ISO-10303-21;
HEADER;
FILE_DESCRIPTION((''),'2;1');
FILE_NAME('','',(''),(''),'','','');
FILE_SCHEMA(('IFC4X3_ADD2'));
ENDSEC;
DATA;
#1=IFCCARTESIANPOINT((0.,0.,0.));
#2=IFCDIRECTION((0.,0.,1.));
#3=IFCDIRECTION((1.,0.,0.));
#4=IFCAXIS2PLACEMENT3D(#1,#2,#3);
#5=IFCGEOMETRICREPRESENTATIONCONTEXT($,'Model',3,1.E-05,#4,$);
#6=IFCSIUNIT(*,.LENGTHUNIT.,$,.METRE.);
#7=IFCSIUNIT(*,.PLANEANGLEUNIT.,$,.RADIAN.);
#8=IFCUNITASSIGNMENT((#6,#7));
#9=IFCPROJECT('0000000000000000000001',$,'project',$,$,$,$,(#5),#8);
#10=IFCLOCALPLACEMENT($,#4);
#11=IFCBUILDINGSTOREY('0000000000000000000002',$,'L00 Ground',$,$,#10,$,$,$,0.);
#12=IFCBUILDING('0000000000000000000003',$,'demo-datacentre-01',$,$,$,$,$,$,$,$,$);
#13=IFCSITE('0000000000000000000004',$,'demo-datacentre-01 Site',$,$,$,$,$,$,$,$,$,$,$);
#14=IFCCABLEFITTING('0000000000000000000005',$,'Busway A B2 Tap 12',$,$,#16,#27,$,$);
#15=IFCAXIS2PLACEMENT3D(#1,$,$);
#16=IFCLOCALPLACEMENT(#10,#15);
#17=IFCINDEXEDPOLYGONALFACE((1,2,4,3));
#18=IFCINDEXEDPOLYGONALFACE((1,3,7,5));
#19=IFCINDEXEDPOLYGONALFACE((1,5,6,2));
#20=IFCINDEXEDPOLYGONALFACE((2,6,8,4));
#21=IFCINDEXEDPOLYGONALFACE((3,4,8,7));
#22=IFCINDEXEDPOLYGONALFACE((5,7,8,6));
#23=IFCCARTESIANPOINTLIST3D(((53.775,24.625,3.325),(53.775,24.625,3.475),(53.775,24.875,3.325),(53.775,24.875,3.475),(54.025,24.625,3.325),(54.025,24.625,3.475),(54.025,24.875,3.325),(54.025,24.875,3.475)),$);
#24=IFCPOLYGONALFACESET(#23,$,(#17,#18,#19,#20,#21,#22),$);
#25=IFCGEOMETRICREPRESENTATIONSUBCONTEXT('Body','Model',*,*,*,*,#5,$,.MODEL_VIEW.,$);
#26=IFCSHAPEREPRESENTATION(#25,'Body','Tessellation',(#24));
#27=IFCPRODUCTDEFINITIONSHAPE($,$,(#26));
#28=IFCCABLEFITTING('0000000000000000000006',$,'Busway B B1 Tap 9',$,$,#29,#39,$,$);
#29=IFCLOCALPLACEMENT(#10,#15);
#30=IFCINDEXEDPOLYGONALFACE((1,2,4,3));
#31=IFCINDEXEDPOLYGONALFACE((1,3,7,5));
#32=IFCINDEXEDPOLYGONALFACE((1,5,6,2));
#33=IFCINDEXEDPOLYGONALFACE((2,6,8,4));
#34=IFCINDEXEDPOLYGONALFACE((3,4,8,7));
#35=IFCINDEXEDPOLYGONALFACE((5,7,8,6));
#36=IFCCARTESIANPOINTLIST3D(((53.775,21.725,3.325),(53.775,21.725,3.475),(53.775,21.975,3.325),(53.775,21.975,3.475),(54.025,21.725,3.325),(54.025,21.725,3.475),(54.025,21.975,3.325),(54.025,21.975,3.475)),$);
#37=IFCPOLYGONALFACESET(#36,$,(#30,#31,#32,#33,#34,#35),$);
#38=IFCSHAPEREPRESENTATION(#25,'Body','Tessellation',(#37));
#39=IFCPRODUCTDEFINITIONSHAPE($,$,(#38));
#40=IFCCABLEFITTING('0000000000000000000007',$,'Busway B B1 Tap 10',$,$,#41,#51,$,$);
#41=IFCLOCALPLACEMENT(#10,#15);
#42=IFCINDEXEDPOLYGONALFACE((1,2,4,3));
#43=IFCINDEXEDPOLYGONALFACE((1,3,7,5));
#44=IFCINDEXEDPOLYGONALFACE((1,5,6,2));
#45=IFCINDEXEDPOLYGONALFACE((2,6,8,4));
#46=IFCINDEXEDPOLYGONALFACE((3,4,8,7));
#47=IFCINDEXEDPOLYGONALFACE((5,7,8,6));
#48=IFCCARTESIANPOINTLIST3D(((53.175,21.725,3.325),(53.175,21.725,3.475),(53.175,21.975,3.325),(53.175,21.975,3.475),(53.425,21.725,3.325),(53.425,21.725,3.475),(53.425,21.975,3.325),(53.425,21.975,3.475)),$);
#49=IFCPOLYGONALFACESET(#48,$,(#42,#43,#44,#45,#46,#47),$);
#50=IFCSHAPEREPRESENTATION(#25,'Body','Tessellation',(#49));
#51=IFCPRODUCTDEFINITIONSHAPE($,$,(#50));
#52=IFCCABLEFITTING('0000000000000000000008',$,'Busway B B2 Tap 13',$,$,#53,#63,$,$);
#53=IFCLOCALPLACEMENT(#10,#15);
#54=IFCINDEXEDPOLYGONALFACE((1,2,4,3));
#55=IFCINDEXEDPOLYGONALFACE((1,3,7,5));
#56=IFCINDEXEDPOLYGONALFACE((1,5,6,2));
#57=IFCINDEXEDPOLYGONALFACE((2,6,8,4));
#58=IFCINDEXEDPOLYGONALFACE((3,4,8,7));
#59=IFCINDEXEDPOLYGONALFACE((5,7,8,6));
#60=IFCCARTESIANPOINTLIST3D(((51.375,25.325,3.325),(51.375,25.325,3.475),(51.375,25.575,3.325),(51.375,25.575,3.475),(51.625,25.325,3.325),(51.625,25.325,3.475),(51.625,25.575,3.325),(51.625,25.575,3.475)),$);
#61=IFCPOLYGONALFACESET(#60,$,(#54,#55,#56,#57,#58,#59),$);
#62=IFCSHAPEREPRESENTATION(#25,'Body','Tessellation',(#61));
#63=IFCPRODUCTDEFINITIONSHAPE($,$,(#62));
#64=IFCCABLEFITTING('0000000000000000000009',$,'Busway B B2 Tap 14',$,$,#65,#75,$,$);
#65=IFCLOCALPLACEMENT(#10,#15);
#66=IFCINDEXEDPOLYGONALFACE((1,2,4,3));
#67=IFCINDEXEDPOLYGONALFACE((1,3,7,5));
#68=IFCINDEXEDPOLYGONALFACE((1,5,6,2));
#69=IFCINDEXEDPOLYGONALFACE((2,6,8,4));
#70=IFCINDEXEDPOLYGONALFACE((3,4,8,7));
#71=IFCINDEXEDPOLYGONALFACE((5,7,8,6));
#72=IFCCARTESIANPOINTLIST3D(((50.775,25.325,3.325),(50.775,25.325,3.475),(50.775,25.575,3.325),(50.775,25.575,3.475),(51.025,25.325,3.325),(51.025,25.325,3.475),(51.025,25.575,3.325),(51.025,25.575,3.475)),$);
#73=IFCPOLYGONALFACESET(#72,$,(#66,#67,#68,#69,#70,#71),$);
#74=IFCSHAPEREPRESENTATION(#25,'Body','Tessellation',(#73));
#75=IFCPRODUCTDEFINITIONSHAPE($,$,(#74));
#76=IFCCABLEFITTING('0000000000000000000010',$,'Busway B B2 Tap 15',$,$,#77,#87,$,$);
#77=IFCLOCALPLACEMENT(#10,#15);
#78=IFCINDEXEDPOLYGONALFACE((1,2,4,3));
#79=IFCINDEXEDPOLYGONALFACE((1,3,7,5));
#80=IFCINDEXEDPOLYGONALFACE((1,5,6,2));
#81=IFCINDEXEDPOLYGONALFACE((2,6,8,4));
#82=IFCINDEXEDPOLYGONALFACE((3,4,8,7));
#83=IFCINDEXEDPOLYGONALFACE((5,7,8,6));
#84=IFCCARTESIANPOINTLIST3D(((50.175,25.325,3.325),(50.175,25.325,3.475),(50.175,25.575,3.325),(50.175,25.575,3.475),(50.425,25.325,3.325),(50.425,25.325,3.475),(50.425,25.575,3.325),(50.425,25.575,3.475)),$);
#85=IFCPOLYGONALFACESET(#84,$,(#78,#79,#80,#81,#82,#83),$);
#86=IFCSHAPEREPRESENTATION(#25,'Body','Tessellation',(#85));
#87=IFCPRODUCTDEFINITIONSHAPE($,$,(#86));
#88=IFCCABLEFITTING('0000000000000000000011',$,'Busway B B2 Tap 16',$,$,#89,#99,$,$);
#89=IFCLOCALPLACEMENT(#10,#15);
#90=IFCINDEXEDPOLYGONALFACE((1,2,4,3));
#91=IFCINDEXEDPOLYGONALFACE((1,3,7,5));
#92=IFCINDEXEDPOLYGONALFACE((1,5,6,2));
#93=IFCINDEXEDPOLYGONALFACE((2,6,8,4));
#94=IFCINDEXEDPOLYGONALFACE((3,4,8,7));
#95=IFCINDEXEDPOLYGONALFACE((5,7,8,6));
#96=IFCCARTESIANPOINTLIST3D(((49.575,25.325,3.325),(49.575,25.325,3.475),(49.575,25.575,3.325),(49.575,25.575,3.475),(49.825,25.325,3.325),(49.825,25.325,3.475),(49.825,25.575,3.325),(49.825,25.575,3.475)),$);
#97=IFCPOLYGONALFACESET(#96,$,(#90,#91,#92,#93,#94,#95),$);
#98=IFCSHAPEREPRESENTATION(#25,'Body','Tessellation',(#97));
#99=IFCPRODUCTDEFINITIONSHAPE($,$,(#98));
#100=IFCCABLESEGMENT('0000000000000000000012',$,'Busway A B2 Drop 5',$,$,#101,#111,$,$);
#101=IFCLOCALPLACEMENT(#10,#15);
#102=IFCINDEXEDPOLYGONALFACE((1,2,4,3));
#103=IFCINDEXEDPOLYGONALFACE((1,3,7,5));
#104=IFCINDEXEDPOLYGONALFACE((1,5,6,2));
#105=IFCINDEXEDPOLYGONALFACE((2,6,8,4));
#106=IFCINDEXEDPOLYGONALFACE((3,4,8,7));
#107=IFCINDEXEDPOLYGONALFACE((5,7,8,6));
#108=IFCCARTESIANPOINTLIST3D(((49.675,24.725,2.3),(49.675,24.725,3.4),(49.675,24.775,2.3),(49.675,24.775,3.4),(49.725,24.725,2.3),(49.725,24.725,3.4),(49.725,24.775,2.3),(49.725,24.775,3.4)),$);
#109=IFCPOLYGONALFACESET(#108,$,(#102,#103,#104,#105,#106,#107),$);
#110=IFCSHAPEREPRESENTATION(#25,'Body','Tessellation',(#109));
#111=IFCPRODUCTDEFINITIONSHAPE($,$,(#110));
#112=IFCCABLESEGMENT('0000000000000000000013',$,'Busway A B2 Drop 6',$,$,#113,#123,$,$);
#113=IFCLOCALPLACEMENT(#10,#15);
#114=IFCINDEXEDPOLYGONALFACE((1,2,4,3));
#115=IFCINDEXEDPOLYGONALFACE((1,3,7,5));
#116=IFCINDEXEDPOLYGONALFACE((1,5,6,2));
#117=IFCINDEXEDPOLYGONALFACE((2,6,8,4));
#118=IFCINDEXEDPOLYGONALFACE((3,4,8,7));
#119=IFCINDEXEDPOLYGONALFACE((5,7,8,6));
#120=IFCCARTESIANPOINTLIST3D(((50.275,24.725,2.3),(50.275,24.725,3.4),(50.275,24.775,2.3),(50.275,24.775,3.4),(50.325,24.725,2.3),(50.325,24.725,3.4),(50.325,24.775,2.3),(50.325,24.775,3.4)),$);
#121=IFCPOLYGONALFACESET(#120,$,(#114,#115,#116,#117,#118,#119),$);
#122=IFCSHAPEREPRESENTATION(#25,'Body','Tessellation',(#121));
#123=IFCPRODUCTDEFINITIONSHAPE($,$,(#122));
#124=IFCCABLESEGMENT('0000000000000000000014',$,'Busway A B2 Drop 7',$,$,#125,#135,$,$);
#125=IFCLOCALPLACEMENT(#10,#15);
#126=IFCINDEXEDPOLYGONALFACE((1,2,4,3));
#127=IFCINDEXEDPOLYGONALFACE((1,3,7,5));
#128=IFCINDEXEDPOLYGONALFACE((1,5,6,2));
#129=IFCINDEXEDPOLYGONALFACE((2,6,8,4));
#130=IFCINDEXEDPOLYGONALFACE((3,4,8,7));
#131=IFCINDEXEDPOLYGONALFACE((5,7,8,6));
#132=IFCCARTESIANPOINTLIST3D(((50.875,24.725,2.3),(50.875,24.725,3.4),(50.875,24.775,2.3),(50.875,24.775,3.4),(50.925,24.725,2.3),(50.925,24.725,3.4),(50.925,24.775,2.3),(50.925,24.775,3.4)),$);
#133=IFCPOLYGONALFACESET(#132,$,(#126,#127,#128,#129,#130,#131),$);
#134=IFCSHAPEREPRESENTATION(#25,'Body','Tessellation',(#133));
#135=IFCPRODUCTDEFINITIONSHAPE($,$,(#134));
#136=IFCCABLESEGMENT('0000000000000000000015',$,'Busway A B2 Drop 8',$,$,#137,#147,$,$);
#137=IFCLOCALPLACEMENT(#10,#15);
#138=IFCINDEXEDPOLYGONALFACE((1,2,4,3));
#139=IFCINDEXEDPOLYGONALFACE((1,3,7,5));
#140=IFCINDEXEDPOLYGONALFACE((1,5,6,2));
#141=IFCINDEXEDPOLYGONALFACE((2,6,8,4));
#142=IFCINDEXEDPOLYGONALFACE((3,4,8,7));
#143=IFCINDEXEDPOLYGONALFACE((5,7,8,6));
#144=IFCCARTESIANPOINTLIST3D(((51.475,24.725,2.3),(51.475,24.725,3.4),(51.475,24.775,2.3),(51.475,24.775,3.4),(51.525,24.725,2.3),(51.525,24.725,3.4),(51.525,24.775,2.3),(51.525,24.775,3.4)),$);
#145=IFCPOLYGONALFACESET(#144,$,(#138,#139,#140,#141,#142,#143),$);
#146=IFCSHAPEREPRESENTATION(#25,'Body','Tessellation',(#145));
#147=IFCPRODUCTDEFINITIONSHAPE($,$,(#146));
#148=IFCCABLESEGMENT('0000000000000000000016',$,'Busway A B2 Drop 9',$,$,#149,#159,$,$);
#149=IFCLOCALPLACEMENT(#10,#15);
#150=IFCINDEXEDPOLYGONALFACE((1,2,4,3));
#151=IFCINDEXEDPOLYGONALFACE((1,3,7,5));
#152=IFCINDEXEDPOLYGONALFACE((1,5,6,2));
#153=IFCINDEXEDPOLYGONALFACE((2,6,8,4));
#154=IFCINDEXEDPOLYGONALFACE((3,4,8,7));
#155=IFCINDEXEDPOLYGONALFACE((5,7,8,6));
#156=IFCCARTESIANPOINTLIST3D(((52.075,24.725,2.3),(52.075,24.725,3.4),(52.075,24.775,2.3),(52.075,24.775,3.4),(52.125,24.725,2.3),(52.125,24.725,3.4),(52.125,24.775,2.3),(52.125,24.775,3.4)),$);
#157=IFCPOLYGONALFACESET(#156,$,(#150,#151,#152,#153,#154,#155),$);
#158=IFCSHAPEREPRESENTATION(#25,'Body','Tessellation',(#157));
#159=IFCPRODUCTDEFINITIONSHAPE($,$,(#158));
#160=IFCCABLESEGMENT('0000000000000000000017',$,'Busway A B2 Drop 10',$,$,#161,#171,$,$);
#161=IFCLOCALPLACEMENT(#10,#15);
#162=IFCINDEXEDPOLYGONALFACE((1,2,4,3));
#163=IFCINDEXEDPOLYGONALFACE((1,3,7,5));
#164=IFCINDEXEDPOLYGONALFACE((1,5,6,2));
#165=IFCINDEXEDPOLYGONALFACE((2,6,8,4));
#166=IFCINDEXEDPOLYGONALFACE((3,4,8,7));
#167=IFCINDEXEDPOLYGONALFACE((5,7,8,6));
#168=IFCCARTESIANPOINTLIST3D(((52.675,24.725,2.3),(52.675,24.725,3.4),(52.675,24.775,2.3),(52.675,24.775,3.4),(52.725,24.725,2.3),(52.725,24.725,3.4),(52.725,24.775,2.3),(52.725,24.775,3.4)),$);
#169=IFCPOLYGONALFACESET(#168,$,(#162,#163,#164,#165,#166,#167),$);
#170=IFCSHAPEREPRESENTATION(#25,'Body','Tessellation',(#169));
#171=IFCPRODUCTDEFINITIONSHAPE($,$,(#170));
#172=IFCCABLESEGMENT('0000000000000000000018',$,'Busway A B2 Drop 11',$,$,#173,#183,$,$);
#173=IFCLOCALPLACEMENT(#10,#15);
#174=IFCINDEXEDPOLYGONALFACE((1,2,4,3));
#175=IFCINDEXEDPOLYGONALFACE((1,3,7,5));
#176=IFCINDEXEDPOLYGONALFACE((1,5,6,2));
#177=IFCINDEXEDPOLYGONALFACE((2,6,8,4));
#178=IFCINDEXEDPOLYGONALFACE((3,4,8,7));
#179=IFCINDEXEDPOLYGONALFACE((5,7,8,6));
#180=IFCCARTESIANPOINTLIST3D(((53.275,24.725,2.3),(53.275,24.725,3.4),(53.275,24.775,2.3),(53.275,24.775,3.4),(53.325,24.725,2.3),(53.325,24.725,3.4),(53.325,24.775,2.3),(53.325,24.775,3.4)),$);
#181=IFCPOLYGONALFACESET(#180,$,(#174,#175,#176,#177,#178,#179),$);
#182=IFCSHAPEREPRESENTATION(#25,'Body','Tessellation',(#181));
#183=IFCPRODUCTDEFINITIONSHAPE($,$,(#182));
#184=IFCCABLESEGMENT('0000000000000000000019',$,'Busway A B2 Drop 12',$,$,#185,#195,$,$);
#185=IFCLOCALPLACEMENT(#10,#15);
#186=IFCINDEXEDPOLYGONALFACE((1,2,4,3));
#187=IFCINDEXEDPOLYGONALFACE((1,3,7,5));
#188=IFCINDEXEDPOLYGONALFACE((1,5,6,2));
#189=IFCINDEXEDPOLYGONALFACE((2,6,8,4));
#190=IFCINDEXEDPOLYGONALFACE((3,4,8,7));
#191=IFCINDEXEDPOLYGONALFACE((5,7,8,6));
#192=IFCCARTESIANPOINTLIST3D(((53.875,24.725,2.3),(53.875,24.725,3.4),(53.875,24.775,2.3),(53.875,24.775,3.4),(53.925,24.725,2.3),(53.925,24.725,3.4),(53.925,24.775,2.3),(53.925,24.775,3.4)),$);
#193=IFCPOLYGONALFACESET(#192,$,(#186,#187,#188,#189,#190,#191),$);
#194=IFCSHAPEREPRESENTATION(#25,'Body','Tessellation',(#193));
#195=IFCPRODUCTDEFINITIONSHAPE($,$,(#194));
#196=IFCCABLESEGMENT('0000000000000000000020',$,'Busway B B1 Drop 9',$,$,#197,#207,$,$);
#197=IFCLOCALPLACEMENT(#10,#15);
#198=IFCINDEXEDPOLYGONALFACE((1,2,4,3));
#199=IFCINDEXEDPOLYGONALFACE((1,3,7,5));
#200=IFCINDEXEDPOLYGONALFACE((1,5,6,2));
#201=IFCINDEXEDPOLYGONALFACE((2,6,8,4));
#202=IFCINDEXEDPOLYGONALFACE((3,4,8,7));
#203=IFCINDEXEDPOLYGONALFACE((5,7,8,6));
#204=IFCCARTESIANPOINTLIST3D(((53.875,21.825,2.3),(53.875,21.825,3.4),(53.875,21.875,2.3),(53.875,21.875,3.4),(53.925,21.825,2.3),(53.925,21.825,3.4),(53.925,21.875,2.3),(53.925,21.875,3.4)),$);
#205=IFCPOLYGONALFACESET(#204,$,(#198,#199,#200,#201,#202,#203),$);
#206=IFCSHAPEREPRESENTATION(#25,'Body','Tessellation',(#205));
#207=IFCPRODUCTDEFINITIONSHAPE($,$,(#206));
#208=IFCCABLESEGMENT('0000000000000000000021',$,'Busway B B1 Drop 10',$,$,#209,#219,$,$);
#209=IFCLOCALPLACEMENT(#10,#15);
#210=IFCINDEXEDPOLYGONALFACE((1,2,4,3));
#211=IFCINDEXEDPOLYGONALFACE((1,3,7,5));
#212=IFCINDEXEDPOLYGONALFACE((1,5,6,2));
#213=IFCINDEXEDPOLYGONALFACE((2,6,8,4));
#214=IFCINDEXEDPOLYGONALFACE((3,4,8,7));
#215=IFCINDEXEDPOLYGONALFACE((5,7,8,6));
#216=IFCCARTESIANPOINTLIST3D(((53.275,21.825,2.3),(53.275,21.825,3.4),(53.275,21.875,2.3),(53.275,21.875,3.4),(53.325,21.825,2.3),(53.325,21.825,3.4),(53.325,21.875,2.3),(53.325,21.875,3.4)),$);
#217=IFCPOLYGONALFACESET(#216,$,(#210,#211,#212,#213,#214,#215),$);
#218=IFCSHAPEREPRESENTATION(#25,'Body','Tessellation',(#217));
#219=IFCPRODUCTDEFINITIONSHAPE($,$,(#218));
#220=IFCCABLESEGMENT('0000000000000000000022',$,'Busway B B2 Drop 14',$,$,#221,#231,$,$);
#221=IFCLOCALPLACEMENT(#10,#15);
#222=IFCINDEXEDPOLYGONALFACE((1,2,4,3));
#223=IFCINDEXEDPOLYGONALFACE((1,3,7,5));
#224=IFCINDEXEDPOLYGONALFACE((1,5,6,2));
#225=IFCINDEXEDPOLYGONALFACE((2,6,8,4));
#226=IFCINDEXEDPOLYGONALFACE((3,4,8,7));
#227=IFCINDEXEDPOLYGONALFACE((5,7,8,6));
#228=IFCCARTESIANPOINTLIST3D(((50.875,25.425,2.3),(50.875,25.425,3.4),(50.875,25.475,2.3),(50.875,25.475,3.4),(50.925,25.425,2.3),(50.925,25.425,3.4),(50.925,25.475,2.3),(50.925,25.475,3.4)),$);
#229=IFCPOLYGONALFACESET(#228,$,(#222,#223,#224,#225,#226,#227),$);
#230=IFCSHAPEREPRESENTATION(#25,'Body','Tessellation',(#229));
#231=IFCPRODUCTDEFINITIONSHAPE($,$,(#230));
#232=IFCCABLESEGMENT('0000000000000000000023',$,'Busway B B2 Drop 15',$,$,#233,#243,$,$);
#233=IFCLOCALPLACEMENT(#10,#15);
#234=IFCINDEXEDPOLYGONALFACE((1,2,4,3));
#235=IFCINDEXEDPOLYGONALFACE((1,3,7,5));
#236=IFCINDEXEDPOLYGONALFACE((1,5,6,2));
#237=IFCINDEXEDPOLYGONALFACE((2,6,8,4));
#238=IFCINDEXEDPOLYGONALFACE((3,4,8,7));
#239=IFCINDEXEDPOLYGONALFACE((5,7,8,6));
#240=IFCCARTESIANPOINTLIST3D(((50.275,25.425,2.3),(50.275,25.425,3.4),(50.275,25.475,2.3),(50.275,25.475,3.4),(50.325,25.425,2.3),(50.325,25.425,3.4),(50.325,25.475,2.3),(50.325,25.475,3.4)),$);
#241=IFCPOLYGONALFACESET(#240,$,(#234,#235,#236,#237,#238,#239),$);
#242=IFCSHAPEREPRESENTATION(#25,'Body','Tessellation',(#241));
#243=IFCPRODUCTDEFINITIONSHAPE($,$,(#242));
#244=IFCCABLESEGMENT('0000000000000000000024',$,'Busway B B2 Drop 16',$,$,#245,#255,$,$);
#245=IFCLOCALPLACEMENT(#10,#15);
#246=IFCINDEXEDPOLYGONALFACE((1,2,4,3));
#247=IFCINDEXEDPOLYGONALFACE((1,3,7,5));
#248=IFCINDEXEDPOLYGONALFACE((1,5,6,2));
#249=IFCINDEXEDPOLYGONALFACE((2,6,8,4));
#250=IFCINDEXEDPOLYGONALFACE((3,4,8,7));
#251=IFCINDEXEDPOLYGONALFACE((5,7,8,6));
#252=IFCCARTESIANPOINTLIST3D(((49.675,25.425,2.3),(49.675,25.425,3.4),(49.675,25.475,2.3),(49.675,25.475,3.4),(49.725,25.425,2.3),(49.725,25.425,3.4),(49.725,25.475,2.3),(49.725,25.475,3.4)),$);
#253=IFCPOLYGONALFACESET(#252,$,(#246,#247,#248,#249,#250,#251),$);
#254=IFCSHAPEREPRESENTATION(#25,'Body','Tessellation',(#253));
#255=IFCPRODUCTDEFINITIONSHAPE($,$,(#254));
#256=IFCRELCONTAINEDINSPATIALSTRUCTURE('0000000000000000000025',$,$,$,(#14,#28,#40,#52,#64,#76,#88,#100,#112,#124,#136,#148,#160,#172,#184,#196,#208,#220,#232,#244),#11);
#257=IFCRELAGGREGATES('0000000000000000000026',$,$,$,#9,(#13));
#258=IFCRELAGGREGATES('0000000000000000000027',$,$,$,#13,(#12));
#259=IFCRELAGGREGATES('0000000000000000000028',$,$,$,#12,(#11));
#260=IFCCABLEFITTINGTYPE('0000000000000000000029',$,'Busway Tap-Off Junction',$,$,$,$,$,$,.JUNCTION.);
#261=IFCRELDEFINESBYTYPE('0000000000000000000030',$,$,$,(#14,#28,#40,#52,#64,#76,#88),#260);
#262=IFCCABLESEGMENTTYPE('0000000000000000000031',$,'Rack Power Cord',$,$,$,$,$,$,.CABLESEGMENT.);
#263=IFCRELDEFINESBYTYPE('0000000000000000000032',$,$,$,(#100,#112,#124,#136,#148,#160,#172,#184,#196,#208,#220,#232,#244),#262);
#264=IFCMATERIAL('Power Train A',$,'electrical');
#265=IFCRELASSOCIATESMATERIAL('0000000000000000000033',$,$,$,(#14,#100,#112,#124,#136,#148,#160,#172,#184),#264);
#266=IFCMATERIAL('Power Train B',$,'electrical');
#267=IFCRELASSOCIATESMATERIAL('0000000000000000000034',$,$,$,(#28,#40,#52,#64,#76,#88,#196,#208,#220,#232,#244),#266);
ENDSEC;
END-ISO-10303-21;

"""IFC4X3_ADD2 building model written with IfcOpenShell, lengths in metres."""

from ifc_helpers import new_model, si_unit, frame, origin_with_axes, place, context, subcontext, project, spatial, rectangle, extrude, material, type_object, element, save


model = new_model("IFC4X3_ADD2")

# Units and contexts
model_context = context("Model", 3, precision=1e-05, world=origin_with_axes())
body_context = subcontext(model_context, "Body", "Model", "MODEL_VIEW")
ifc_project = project(units=[si_unit("LENGTHUNIT", "METRE"), si_unit("PLANEANGLEUNIT", "RADIAN")], contexts=[model_context])

# Site, building, storey
site = spatial("IfcSite", under=ifc_project, Name="demo-datacentre-01 Site")
building = spatial("IfcBuilding", under=site, Name="demo-datacentre-01")
storey_placement = place(None, origin_with_axes())
storey = spatial("IfcBuildingStorey", under=building, at=storey_placement, Name="L00 Ground", Elevation=0.0)

# Shared definitions
ifc_material_1 = material(Name="Power Train A", Category="electrical")
ifc_material_2 = material(Name="Power Train B", Category="electrical")

# Cable fittings
cable_fitting_type = type_object("IfcCableFittingType", Name="Busway Tap-Off Junction", PredefinedType="JUNCTION")
for number, where, z_axis, x_axis, name in (
    (1, (53.9, 24.75, 3.325), (0.0, 0.0, 1.0), (1.0, 0.0, 0.0), "Busway A B2 Tap 12"),
):
    element("IfcCableFitting", number, at=place(storey_placement, frame(where, z_axis=z_axis, x_axis=x_axis)), inside=storey, type_object=cable_fitting_type, material=ifc_material_1, Name=name, context=body_context, shape_type="SweptSolid", body=[
        extrude(rectangle(XDim=0.25, YDim=0.25), origin_with_axes(), (0.0, 0.0, 1.0), 0.15),
    ])
for number, where, z_axis, x_axis, name in (
    (2, (53.9, 21.85, 3.325), (0.0, 0.0, 1.0), (1.0, 0.0, 0.0), "Busway B B1 Tap 9"),
    (3, (53.3, 21.85, 3.325), (0.0, 0.0, 1.0), (1.0, 0.0, 0.0), "Busway B B1 Tap 10"),
    (4, (51.5, 25.45, 3.325), (0.0, 0.0, 1.0), (1.0, 0.0, 0.0), "Busway B B2 Tap 13"),
    (5, (50.9, 25.45, 3.325), (0.0, 0.0, 1.0), (1.0, 0.0, 0.0), "Busway B B2 Tap 14"),
    (6, (50.3, 25.45, 3.325), (0.0, 0.0, 1.0), (1.0, 0.0, 0.0), "Busway B B2 Tap 15"),
    (7, (49.7, 25.45, 3.325), (0.0, 0.0, 1.0), (1.0, 0.0, 0.0), "Busway B B2 Tap 16"),
):
    element("IfcCableFitting", number, at=place(storey_placement, frame(where, z_axis=z_axis, x_axis=x_axis)), inside=storey, type_object=cable_fitting_type, material=ifc_material_2, Name=name, context=body_context, shape_type="SweptSolid", body=[
        extrude(rectangle(XDim=0.25, YDim=0.25), origin_with_axes(), (0.0, 0.0, 1.0), 0.15),
    ])

# Cable segments
cable_segment_type_1 = type_object("IfcCableSegmentType", Name="Rack Power Cord", PredefinedType="CABLESEGMENT")
for number, where, z_axis, x_axis, name in (
    (8, (49.7, 24.75, 3.4), (0.0, 0.0, -1.0), (1.0, 0.0, 0.0), "Busway A B2 Drop 5"),
    (9, (50.3, 24.75, 3.4), (0.0, 0.0, -1.0), (1.0, 0.0, 0.0), "Busway A B2 Drop 6"),
    (10, (50.9, 24.75, 3.4), (0.0, 0.0, -1.0), (1.0, 0.0, 0.0), "Busway A B2 Drop 7"),
    (11, (51.5, 24.75, 3.4), (0.0, 0.0, -1.0), (1.0, 0.0, 0.0), "Busway A B2 Drop 8"),
    (12, (52.1, 24.75, 3.4), (0.0, 0.0, -1.0), (1.0, 0.0, 0.0), "Busway A B2 Drop 9"),
    (13, (52.7, 24.75, 3.4), (0.0, 0.0, -1.0), (1.0, 0.0, 0.0), "Busway A B2 Drop 10"),
    (14, (53.3, 24.75, 3.4), (0.0, 0.0, -1.0), (1.0, 0.0, 0.0), "Busway A B2 Drop 11"),
    (15, (53.9, 24.75, 3.4), (0.0, 0.0, -1.0), (1.0, 0.0, 0.0), "Busway A B2 Drop 12"),
):
    element("IfcCableSegment", number, at=place(storey_placement, frame(where, z_axis=z_axis, x_axis=x_axis)), inside=storey, type_object=cable_segment_type_1, material=ifc_material_1, Name=name, context=body_context, shape_type="SweptSolid", body=[
        extrude(rectangle(XDim=0.05, YDim=0.05), origin_with_axes(), (0.0, 0.0, 1.0), 1.1),
    ])
for number, where, z_axis, x_axis, name in (
    (16, (53.9, 21.85, 3.4), (0.0, 0.0, -1.0), (1.0, 0.0, 0.0), "Busway B B1 Drop 9"),
    (17, (53.3, 21.85, 3.4), (0.0, 0.0, -1.0), (1.0, 0.0, 0.0), "Busway B B1 Drop 10"),
    (18, (50.9, 25.45, 3.4), (0.0, 0.0, -1.0), (1.0, 0.0, 0.0), "Busway B B2 Drop 14"),
    (19, (50.3, 25.45, 3.4), (0.0, 0.0, -1.0), (1.0, 0.0, 0.0), "Busway B B2 Drop 15"),
    (20, (49.7, 25.45, 3.4), (0.0, 0.0, -1.0), (1.0, 0.0, 0.0), "Busway B B2 Drop 16"),
):
    element("IfcCableSegment", number, at=place(storey_placement, frame(where, z_axis=z_axis, x_axis=x_axis)), inside=storey, type_object=cable_segment_type_1, material=ifc_material_2, Name=name, context=body_context, shape_type="SweptSolid", body=[
        extrude(rectangle(XDim=0.05, YDim=0.05), origin_with_axes(), (0.0, 0.0, 1.0), 1.1),
    ])

save(model, "model.ifc")
